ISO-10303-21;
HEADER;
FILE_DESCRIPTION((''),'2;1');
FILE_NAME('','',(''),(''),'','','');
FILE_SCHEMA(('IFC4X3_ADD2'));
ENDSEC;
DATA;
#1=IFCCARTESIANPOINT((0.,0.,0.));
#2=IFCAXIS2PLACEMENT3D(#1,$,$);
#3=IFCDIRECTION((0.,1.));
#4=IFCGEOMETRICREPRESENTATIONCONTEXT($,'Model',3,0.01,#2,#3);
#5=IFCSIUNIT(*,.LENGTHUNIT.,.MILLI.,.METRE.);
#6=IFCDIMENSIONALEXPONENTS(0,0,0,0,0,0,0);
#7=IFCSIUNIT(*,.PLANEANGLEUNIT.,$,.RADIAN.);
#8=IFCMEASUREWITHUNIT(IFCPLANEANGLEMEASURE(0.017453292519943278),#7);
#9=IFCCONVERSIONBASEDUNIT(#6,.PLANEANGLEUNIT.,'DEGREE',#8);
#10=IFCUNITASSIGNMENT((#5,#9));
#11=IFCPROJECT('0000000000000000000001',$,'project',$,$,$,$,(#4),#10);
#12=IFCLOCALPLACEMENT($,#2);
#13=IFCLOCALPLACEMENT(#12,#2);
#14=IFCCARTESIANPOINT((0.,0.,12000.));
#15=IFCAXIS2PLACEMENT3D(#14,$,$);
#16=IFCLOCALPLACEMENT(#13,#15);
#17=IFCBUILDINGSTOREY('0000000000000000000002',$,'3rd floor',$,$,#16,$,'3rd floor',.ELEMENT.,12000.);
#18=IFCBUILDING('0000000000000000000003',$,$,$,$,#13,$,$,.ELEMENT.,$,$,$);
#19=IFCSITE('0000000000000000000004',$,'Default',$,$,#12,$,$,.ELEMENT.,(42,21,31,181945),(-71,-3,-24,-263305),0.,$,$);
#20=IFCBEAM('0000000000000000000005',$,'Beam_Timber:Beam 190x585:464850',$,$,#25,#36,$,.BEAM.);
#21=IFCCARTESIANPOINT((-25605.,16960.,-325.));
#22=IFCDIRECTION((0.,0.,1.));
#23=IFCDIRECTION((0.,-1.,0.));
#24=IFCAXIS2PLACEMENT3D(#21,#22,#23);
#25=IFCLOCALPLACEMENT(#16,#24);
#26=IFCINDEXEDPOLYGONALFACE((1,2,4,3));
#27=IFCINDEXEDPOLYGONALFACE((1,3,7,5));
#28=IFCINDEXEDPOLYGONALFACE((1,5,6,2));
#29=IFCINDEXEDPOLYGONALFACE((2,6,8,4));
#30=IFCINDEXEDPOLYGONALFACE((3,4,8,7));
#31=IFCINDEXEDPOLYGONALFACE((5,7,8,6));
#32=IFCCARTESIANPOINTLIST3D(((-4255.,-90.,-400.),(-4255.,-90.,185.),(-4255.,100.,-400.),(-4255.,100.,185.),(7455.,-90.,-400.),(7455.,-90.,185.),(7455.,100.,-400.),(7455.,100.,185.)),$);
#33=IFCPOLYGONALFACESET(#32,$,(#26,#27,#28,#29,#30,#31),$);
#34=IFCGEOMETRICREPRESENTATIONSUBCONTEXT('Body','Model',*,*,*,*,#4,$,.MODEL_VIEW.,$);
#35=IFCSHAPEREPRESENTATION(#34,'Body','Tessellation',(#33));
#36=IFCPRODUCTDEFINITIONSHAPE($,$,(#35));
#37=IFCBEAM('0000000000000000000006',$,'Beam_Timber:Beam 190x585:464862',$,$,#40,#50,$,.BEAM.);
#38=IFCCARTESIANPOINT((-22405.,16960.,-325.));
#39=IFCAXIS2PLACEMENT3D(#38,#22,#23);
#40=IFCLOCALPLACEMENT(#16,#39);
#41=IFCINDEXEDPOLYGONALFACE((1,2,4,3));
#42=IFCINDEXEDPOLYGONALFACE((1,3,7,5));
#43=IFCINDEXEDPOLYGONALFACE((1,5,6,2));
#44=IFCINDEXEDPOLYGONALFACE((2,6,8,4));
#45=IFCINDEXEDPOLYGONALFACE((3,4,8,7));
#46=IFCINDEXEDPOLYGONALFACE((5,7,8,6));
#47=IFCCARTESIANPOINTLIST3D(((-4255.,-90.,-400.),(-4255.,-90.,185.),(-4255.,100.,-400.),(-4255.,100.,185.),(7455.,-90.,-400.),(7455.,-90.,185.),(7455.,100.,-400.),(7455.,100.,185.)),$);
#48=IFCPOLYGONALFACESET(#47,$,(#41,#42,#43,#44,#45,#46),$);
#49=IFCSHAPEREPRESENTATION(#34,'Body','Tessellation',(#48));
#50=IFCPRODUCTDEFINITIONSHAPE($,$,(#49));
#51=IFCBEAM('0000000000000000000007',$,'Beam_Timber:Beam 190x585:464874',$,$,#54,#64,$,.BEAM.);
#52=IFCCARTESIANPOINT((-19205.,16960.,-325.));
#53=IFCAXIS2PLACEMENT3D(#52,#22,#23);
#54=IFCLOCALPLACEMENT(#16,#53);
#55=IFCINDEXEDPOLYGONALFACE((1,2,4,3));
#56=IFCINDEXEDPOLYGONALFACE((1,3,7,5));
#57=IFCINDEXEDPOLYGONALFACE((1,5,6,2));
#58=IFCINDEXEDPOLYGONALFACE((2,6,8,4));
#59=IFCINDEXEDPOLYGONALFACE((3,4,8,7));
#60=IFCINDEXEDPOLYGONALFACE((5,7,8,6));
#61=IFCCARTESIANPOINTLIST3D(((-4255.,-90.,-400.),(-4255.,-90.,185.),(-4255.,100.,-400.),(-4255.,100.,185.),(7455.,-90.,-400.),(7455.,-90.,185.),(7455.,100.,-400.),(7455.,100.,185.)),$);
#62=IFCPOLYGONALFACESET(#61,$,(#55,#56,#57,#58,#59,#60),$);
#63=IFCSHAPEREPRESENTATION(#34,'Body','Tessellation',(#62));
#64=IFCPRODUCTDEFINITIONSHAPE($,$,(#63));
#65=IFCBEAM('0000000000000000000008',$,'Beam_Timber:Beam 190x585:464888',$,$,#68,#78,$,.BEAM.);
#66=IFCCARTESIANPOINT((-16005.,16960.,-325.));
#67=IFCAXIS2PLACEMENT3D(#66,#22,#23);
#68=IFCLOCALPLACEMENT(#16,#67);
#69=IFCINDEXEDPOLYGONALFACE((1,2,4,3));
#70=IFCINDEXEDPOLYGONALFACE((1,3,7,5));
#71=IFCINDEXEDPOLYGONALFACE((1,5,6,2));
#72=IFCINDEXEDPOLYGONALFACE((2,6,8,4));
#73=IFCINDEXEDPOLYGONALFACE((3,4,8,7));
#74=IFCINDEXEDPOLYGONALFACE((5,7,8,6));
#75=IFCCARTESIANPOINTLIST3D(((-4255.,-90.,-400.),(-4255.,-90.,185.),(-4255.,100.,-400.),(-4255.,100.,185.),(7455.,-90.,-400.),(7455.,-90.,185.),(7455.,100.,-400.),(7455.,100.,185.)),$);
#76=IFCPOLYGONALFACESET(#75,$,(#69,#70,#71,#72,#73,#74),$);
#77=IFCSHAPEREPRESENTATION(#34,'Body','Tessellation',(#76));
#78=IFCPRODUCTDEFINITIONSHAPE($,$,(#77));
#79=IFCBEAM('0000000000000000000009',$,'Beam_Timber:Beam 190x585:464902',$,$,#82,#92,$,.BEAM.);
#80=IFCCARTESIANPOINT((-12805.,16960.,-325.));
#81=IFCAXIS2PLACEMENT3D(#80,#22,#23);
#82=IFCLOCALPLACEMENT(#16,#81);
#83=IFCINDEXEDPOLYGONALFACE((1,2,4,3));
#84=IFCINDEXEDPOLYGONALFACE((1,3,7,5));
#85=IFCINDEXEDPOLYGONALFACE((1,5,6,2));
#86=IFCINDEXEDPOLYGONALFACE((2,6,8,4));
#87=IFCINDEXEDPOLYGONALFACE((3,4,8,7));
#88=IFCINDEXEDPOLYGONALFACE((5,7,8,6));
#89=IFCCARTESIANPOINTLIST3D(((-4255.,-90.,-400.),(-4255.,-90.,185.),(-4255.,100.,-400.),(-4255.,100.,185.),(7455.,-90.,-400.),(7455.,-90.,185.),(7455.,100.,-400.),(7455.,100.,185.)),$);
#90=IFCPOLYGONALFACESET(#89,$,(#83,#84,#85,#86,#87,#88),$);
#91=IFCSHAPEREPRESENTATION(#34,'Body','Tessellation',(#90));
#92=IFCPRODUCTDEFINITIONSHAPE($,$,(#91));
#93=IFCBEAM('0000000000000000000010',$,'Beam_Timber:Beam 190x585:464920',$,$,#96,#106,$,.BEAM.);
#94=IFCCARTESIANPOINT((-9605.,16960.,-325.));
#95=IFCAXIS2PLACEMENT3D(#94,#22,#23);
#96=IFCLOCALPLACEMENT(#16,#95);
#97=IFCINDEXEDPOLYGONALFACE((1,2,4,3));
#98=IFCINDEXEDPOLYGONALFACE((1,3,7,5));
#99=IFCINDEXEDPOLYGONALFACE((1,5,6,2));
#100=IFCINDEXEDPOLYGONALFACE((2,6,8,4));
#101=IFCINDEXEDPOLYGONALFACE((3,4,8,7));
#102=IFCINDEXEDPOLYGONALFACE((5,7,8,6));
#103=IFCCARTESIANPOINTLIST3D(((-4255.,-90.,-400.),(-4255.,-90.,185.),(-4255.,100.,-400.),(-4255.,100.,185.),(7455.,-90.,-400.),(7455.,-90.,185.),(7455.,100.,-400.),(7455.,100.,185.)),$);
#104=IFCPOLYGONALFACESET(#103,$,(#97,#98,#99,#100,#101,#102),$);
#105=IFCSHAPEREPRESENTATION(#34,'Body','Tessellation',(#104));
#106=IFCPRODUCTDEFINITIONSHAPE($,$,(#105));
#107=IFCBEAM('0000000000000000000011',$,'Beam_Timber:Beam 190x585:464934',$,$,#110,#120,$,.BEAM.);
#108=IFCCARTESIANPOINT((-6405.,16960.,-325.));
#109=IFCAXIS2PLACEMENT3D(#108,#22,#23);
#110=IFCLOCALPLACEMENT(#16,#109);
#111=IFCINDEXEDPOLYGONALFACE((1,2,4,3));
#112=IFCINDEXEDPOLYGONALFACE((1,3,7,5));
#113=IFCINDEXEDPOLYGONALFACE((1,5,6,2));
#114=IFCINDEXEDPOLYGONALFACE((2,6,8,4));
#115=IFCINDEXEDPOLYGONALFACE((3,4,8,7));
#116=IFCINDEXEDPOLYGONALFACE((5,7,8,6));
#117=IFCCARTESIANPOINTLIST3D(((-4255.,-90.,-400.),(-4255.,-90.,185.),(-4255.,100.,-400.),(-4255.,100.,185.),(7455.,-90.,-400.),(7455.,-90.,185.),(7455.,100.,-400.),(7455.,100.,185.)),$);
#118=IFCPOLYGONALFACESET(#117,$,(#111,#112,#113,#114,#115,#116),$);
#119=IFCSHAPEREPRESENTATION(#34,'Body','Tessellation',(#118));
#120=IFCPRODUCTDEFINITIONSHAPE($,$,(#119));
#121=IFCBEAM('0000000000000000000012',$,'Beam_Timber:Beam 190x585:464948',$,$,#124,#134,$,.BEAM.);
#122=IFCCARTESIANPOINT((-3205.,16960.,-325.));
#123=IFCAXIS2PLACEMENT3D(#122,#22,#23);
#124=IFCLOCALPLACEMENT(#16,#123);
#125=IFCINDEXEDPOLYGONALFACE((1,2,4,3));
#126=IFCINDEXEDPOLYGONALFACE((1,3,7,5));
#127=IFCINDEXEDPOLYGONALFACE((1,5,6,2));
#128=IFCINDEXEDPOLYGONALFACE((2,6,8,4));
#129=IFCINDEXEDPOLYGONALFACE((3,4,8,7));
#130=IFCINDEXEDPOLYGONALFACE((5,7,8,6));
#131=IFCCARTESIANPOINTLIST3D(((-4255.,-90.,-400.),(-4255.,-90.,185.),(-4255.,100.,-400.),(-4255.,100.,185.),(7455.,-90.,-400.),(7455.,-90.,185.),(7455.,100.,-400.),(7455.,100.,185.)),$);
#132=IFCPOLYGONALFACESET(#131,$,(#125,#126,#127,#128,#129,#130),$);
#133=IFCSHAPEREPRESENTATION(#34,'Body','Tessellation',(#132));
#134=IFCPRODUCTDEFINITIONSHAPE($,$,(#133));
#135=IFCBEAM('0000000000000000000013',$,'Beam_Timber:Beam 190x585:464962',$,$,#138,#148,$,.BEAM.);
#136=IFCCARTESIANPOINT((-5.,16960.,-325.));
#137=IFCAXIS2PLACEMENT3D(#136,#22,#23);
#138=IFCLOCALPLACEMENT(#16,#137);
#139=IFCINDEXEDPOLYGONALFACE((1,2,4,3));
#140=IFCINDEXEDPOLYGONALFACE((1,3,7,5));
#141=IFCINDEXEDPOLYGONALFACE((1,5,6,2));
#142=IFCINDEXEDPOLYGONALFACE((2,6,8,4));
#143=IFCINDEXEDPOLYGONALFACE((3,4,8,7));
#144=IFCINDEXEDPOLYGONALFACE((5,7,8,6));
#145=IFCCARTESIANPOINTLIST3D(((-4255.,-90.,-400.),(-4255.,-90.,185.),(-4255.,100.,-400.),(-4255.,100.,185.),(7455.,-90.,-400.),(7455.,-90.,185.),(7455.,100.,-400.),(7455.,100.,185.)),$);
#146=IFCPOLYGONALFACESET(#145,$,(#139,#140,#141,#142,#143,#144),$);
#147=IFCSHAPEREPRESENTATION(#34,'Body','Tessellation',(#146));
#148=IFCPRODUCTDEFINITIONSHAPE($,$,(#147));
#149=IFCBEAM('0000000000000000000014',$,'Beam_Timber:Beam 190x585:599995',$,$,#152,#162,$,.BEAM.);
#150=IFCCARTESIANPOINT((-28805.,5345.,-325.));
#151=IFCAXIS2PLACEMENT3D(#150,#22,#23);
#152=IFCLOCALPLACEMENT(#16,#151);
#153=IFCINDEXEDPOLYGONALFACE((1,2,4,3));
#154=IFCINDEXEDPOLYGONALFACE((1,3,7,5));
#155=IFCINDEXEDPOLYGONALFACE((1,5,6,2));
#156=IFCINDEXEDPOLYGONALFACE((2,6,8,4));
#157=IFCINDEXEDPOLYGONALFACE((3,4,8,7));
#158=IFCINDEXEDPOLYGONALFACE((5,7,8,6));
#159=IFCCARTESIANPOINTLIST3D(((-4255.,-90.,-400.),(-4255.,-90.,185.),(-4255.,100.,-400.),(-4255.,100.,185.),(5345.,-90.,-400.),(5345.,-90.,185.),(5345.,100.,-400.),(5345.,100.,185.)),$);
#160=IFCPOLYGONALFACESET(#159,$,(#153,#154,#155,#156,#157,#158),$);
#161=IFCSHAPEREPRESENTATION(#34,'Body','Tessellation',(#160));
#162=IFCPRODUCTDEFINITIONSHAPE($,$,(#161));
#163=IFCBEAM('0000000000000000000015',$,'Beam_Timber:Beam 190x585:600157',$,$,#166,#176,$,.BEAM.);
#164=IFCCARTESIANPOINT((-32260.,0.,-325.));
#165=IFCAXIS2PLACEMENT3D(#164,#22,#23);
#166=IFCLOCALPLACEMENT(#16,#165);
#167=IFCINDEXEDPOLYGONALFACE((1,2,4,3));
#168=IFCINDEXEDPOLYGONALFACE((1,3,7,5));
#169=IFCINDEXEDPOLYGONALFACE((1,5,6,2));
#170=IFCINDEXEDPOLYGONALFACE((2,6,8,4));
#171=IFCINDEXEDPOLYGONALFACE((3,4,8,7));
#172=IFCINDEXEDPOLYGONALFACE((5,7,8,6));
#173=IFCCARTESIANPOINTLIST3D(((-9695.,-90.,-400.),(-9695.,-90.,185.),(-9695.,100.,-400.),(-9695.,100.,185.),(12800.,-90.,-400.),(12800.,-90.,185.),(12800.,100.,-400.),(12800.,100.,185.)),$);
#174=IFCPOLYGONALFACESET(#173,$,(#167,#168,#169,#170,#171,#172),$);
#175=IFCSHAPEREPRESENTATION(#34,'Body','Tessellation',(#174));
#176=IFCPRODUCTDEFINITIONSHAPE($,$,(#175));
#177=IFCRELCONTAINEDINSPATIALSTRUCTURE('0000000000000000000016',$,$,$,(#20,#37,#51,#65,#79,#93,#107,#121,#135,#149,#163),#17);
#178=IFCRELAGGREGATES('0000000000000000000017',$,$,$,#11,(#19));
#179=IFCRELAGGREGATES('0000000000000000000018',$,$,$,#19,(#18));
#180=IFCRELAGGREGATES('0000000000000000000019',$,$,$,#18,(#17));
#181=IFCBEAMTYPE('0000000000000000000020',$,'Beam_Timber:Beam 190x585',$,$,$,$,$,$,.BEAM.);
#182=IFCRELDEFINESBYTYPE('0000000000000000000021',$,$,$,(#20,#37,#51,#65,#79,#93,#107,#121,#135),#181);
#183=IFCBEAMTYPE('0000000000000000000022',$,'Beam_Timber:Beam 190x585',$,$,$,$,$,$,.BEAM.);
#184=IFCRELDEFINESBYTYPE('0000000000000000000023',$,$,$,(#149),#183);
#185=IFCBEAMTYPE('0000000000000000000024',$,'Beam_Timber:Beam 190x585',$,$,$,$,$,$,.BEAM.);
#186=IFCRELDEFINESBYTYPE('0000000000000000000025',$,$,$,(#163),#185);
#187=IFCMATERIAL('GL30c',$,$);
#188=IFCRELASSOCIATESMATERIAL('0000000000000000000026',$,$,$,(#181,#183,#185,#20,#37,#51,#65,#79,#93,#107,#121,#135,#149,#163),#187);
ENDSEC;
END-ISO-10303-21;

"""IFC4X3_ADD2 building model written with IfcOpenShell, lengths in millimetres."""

from ifc_helpers import new_model, entity, si_unit, converted_unit, direction, frame, origin, origin_2d_with_axis, place, context, subcontext, project, spatial, rectangle, extrude, source, transform, mapped, material, material_profile, profile_set, profile_usage, type_object, type_shapes, element, save


model = new_model("IFC4X3_ADD2")

# Units and contexts
model_context = context("Model", 3, precision=0.01, world=origin(), true_north=direction((0.0, 1.0)))
body_context = subcontext(model_context, "Body", "Model", "MODEL_VIEW")
ifc_project = project(units=[si_unit("LENGTHUNIT", "METRE", prefix="MILLI"), converted_unit("PLANEANGLEUNIT", "DEGREE", entity("IfcPlaneAngleMeasure", 0.017453292519943278), si_unit("PLANEANGLEUNIT", "RADIAN"), dimensions=[0, 0, 0, 0, 0, 0, 0])], contexts=[model_context])

# Site, building, storey
site_placement = place(None, origin())
site = spatial("IfcSite", under=ifc_project, at=site_placement, Name="Default", CompositionType="ELEMENT", RefLatitude=(42, 21, 31, 181945), RefLongitude=(-71, -3, -24, -263305), RefElevation=0.0)
building_placement = place(site_placement, origin())
building = spatial("IfcBuilding", under=site, at=building_placement, CompositionType="ELEMENT")
storey_placement = place(building_placement, frame((0.0, 0.0, 12000.0)))
storey = spatial("IfcBuildingStorey", under=building, at=storey_placement, Name="3rd floor", LongName="3rd floor", CompositionType="ELEMENT", Elevation=12000.0)

# Beams
ifc_material_1 = material(Name="GL30c")
ifc_material_profile_1 = material_profile(ifc_material_1, rectangle(XDim=5490.0, YDim=190.0, at=origin_2d_with_axis()), Name="Beam 190x585")
ifc_profile_set_1 = profile_set([ifc_material_profile_1], Name="Beam 190x585")
ifc_profile_usage_1 = profile_usage(ifc_profile_set_1, cardinal=8)
beam_type_1 = type_object("IfcBeamType", Name="Beam_Timber:Beam 190x585", PredefinedType="BEAM", material=ifc_profile_set_1)
shared_shape_1 = source(origin(), body_context, "Body", "SweptSolid", [
    extrude(rectangle(XDim=11710.0, YDim=190.0, at=origin_2d_with_axis()), frame((1600.0, 5.0, -400.0), z_axis=(0.0, 0.0, 1.0), x_axis=(-1.0, 0.0, 0.0)), (0.0, 0.0, 1.0), 585.0),
])
type_shapes(beam_type_1, [shared_shape_1])
for number, where, z_axis, x_axis, name in (
    (1, (-25605.0, 16960.0, -325.0), (0.0, 0.0, 1.0), (0.0, -1.0, 0.0), "Beam_Timber:Beam 190x585:464850"),
    (2, (-22405.0, 16960.0, -325.0), (0.0, 0.0, 1.0), (0.0, -1.0, 0.0), "Beam_Timber:Beam 190x585:464862"),
    (3, (-19205.0, 16960.0, -325.0), (0.0, 0.0, 1.0), (0.0, -1.0, 0.0), "Beam_Timber:Beam 190x585:464874"),
    (4, (-16005.0, 16960.0, -325.0), (0.0, 0.0, 1.0), (0.0, -1.0, 0.0), "Beam_Timber:Beam 190x585:464888"),
    (5, (-12805.0, 16960.0, -325.0), (0.0, 0.0, 1.0), (0.0, -1.0, 0.0), "Beam_Timber:Beam 190x585:464902"),
    (6, (-9605.0, 16960.0, -325.0), (0.0, 0.0, 1.0), (0.0, -1.0, 0.0), "Beam_Timber:Beam 190x585:464920"),
    (7, (-6405.0, 16960.0, -325.0), (0.0, 0.0, 1.0), (0.0, -1.0, 0.0), "Beam_Timber:Beam 190x585:464934"),
    (8, (-3205.0, 16960.0, -325.0), (0.0, 0.0, 1.0), (0.0, -1.0, 0.0), "Beam_Timber:Beam 190x585:464948"),
    (9, (-5.0, 16960.0, -325.0), (0.0, 0.0, 1.0), (0.0, -1.0, 0.0), "Beam_Timber:Beam 190x585:464962"),
):
    element("IfcBeam", number, at=place(storey_placement, frame(where, z_axis=z_axis, x_axis=x_axis)), inside=storey, type_object=beam_type_1, material=ifc_profile_usage_1, Name=name, PredefinedType="BEAM", context=body_context, shape_type="MappedRepresentation", body=[
        mapped(shared_shape_1, transform((0.0, 0.0, 0.0), scale=1.0)),
    ])
beam_type_2 = type_object("IfcBeamType", Name="Beam_Timber:Beam 190x585", PredefinedType="BEAM", material=ifc_profile_set_1)
shared_shape_2 = source(origin(), body_context, "Body", "SweptSolid", [
    extrude(rectangle(XDim=9600.0, YDim=190.0, at=origin_2d_with_axis()), frame((545.0, 5.0, -400.0), z_axis=(0.0, 0.0, 1.0), x_axis=(-1.0, 0.0, 0.0)), (0.0, 0.0, 1.0), 585.0),
])
type_shapes(beam_type_2, [shared_shape_2])
beam_1_placement = place(storey_placement, frame((-28805.0, 5345.0, -325.0), z_axis=(0.0, 0.0, 1.0), x_axis=(0.0, -1.0, 0.0)))
element("IfcBeam", 10, at=beam_1_placement, inside=storey, type_object=beam_type_2, material=ifc_profile_usage_1, Name="Beam_Timber:Beam 190x585:599995", PredefinedType="BEAM", context=body_context, shape_type="MappedRepresentation", body=[
    mapped(shared_shape_2, transform((0.0, 0.0, 0.0), scale=1.0)),
])
beam_type_3 = type_object("IfcBeamType", Name="Beam_Timber:Beam 190x585", PredefinedType="BEAM", material=ifc_profile_set_1)
shared_shape_3 = source(origin(), body_context, "Body", "SweptSolid", [
    extrude(rectangle(XDim=22495.0, YDim=190.0, at=origin_2d_with_axis()), frame((1552.5, 5.0, -400.0), z_axis=(0.0, 0.0, 1.0), x_axis=(-1.0, 0.0, 0.0)), (0.0, 0.0, 1.0), 585.0),
])
type_shapes(beam_type_3, [shared_shape_3])
beam_2_placement = place(storey_placement, frame((-32260.0, 0.0, -325.0), z_axis=(0.0, 0.0, 1.0), x_axis=(0.0, -1.0, 0.0)))
element("IfcBeam", 11, at=beam_2_placement, inside=storey, type_object=beam_type_3, material=ifc_profile_usage_1, Name="Beam_Timber:Beam 190x585:600157", PredefinedType="BEAM", context=body_context, shape_type="MappedRepresentation", body=[
    mapped(shared_shape_3, transform((0.0, 0.0, 0.0), scale=1.0)),
])

save(model, "model.ifc")
